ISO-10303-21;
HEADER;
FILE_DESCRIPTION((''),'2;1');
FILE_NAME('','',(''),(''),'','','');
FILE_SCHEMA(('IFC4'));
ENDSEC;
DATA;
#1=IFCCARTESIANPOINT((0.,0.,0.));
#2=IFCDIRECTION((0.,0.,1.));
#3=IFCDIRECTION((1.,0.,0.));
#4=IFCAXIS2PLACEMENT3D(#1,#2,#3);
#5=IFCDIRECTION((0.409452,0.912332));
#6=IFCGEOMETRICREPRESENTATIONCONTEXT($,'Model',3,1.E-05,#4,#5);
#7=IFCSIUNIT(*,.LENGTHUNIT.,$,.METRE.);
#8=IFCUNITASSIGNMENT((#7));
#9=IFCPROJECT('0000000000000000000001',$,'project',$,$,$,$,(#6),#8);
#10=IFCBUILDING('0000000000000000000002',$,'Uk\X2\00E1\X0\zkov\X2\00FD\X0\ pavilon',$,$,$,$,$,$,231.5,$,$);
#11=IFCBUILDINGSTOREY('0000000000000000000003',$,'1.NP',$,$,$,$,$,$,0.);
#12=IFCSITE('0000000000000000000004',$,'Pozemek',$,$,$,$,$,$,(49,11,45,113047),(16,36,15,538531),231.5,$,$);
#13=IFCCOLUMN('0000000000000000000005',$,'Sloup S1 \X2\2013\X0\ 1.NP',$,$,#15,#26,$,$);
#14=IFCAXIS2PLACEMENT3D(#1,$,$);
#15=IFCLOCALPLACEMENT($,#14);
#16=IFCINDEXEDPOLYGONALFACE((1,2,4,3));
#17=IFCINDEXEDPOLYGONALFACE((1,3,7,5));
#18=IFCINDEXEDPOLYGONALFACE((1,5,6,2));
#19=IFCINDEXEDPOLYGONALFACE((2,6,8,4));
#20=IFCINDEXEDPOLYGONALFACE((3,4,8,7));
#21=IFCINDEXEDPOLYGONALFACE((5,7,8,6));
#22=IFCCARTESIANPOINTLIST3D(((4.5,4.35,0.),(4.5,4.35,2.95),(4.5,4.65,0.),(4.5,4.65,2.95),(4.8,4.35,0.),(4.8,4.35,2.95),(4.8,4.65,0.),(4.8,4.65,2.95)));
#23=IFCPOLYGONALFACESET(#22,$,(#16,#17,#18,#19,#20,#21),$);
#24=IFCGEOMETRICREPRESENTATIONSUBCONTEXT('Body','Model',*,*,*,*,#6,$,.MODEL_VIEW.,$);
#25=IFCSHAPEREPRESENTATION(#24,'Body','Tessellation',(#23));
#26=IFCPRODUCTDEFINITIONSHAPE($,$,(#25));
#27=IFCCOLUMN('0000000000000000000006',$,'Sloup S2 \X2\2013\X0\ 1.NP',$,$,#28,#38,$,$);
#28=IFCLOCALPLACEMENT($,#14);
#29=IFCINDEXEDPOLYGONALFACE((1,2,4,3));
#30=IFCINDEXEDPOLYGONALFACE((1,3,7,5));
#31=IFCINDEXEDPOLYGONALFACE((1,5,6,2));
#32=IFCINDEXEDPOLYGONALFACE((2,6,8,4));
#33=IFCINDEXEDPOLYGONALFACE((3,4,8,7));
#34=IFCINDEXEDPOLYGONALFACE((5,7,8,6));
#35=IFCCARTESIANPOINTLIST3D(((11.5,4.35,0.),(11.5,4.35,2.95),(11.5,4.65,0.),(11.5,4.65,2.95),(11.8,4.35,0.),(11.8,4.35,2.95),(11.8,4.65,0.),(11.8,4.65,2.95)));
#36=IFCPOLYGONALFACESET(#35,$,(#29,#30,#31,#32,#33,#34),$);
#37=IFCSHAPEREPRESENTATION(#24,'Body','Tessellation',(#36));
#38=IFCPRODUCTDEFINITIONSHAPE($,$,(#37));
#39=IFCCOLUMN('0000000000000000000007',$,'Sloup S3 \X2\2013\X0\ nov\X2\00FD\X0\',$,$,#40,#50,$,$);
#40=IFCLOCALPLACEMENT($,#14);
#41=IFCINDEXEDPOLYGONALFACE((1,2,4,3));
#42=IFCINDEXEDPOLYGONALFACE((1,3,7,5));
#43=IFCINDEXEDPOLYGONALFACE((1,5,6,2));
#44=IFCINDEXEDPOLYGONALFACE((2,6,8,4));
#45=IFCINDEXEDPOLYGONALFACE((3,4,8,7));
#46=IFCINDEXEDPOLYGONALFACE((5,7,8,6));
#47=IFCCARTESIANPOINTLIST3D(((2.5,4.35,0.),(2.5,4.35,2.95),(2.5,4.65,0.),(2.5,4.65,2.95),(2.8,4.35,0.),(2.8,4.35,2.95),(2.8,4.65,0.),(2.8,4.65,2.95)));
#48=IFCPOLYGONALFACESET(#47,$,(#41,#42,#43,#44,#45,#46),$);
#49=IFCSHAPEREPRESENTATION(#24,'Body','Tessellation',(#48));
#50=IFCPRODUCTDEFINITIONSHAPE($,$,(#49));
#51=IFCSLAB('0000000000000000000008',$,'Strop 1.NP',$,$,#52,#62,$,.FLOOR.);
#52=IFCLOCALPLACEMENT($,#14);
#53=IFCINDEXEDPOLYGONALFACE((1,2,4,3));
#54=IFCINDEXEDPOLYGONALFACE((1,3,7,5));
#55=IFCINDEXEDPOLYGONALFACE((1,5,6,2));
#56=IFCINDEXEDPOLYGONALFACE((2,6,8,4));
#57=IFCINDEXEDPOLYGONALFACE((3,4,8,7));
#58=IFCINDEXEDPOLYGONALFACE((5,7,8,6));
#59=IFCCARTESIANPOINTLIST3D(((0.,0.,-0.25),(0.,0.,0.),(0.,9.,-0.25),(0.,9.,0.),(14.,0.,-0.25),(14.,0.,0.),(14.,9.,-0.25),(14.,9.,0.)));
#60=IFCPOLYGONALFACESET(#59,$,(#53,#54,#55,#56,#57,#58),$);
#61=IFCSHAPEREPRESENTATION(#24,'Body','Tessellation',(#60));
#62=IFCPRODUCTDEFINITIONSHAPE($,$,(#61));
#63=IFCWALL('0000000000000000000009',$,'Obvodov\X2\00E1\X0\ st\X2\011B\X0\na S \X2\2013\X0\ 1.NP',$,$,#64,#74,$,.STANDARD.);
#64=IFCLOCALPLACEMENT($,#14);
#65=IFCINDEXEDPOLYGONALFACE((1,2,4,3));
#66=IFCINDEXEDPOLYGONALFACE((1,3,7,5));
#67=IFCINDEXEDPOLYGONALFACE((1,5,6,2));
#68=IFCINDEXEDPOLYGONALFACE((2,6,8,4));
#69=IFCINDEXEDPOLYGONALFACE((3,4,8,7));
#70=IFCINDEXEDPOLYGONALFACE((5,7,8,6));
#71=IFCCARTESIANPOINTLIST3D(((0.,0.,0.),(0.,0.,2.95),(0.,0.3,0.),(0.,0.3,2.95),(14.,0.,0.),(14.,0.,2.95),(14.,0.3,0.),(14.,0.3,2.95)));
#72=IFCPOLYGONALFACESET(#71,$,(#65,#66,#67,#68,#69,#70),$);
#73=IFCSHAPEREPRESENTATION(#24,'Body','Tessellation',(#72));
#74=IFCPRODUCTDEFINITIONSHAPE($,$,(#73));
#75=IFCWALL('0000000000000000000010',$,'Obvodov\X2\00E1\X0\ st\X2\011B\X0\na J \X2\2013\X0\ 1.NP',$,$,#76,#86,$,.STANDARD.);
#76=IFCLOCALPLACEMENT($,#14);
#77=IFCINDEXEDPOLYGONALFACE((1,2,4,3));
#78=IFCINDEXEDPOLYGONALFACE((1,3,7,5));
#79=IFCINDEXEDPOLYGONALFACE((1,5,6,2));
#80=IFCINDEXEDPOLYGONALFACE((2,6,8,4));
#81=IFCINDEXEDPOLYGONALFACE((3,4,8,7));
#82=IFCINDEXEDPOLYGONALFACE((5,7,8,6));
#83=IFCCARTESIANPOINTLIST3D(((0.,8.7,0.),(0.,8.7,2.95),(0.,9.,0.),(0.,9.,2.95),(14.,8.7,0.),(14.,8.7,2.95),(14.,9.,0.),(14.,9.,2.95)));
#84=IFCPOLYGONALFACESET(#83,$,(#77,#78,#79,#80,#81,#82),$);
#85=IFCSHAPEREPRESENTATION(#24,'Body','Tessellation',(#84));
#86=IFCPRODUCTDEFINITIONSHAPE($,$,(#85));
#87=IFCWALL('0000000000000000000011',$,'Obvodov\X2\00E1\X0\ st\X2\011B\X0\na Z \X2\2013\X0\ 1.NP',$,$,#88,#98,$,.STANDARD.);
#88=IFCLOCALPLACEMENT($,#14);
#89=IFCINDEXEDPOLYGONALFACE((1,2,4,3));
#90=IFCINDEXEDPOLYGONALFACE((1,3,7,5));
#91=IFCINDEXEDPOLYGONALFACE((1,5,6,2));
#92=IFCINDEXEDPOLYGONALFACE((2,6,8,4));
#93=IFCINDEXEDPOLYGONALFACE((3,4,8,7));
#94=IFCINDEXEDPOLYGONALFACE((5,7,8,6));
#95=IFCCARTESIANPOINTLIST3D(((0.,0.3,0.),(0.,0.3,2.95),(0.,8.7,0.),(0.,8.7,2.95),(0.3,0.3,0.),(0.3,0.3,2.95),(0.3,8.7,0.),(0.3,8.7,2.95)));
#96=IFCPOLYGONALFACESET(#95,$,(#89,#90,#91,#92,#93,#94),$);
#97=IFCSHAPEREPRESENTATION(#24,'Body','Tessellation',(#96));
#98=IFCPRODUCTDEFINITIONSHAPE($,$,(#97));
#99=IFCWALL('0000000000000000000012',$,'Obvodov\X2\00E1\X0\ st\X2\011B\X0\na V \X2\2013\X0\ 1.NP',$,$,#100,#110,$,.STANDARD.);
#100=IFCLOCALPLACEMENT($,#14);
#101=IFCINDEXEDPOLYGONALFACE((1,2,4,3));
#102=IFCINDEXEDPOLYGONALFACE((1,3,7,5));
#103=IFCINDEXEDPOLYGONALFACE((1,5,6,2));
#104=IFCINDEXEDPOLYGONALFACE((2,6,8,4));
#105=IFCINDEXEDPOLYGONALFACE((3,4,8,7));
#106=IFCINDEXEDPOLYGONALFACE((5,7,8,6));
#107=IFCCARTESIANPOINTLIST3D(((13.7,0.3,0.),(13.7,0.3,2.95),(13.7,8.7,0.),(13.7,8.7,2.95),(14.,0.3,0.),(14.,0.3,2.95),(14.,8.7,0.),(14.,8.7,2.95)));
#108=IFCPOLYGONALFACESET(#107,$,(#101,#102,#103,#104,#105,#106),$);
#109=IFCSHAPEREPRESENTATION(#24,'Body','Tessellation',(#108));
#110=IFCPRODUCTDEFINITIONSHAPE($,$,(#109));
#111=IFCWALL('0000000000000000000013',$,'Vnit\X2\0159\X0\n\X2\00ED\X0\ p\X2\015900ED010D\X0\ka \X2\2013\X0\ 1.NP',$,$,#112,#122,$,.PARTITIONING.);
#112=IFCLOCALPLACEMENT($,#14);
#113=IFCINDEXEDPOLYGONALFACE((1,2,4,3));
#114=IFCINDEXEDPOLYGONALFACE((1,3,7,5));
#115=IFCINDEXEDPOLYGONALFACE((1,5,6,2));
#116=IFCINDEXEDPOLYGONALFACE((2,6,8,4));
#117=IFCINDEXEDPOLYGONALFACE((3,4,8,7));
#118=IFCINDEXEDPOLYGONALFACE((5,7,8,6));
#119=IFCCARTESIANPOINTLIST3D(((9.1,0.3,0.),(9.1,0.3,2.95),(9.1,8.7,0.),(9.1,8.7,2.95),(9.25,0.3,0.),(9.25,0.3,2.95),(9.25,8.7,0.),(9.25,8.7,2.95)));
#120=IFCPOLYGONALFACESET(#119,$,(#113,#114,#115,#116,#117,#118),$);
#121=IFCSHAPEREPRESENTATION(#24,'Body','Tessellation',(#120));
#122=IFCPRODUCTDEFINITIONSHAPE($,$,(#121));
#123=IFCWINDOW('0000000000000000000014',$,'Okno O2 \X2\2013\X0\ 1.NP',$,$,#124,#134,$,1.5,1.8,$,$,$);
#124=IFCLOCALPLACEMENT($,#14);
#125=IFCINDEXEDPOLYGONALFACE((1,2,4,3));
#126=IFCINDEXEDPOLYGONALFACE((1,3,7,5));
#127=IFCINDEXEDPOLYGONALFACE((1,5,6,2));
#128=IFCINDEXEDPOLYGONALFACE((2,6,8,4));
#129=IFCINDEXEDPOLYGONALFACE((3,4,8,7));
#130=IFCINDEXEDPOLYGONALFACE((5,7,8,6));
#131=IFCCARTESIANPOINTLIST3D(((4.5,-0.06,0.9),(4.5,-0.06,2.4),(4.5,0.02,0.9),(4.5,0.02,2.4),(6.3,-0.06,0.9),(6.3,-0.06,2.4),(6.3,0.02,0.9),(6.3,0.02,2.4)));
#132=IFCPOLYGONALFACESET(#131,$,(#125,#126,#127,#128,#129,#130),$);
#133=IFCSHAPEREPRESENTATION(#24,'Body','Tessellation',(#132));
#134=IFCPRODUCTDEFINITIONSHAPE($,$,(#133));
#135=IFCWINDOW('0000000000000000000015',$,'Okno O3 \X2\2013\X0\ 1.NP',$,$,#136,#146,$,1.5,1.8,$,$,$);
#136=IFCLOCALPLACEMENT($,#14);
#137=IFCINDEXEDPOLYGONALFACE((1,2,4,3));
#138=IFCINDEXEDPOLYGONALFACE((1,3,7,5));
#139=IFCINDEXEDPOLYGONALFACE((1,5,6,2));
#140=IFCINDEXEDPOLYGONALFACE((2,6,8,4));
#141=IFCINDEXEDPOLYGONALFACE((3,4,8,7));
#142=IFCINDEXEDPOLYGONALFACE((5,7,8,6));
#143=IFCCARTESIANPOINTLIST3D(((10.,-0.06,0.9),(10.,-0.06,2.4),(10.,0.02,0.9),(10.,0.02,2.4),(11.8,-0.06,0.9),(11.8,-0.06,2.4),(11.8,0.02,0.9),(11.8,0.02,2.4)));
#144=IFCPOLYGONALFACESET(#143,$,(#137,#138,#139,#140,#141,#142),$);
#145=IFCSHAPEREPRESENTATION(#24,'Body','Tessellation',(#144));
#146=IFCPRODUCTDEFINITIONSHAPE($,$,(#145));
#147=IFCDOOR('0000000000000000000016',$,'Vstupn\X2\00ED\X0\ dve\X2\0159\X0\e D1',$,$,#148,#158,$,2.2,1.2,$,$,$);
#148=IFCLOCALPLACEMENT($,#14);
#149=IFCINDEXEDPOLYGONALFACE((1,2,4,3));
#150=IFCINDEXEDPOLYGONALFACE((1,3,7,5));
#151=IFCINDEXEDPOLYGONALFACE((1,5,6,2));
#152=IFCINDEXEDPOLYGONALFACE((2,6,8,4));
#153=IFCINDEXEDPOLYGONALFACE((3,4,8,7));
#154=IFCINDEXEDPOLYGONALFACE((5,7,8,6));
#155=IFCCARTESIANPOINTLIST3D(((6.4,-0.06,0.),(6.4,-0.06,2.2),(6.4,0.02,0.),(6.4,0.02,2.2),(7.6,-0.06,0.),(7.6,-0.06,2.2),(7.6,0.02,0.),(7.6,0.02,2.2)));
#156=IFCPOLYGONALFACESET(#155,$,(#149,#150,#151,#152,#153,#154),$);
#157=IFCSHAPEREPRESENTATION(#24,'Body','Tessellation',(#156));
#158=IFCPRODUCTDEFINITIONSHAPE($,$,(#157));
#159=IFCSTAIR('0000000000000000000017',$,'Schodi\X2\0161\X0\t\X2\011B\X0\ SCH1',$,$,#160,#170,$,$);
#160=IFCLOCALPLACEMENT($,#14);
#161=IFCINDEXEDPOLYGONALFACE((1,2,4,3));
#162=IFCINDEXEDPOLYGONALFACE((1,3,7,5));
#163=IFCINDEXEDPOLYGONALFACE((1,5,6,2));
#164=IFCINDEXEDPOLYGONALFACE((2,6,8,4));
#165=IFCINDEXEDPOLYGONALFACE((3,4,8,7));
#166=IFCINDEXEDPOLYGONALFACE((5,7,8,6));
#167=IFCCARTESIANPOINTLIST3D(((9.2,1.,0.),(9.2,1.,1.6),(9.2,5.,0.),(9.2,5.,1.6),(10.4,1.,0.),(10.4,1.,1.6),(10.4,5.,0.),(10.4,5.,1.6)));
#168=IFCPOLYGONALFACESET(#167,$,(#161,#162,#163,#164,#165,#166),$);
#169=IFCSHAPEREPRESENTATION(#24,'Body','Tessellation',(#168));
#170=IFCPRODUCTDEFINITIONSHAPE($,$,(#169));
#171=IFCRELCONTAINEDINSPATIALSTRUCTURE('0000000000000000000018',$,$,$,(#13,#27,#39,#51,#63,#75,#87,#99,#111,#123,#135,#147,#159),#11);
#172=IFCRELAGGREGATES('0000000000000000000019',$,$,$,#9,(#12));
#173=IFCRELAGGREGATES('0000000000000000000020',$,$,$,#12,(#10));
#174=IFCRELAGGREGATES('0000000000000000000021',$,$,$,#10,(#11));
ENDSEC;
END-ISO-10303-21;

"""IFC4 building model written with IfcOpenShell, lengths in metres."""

from ifc_helpers import new_model, si_unit, direction, frame, frame_2d, origin, origin_with_axes, place, context, subcontext, project, spatial, rectangle, extrude, element, save


model = new_model("IFC4")

# Units and contexts
model_context = context("Model", 3, precision=1e-05, world=origin_with_axes(), true_north=direction((0.409452, 0.912332)))
body_context = subcontext(model_context, "Body", "Model", "MODEL_VIEW")
ifc_project = project(units=[si_unit("LENGTHUNIT", "METRE")], contexts=[model_context])

# Site, building, storey
site = spatial("IfcSite", under=ifc_project, Name="Pozemek", RefLatitude=(49, 11, 45, 113047), RefLongitude=(16, 36, 15, 538531), RefElevation=231.5)
building = spatial("IfcBuilding", under=site, Name="Ukázkový pavilon", ElevationOfRefHeight=231.5)
storey = spatial("IfcBuildingStorey", under=building, Name="1.NP", Elevation=0.0)

# Columns
for number, where, z_axis, x_axis, name in (
    (1, (4.5, 4.35, 0.0), (0.0, 0.0, 1.0), (1.0, 0.0, 0.0), "Sloup S1 – 1.NP"),
    (2, (11.5, 4.35, 0.0), (0.0, 0.0, 1.0), (1.0, 0.0, 0.0), "Sloup S2 – 1.NP"),
    (3, (2.5, 4.35, 0.0), (0.0, 0.0, 1.0), (1.0, 0.0, 0.0), "Sloup S3 – nový"),
):
    element("IfcColumn", number, at=place(None, frame(where, z_axis=z_axis, x_axis=x_axis)), inside=storey, Name=name, context=body_context, shape_type="SweptSolid", body=[
        extrude(rectangle(XDim=0.3, YDim=0.3, at=frame_2d((0.15, 0.15))), origin(), (0.0, 0.0, 1.0), 2.95),
    ])

# Slab
slab_placement = place(None, frame((0.0, 0.0, -0.25), z_axis=(0.0, 0.0, 1.0), x_axis=(1.0, 0.0, 0.0)))
element("IfcSlab", 4, at=slab_placement, inside=storey, Name="Strop 1.NP", PredefinedType="FLOOR", context=body_context, shape_type="SweptSolid", body=[
    extrude(rectangle(XDim=14.0, YDim=9.0, at=frame_2d((7.0, 4.5))), origin(), (0.0, 0.0, 1.0), 0.25),
])

# Walls
for number, where, z_axis, x_axis, name in (
    (5, (0.0, 0.0, 0.0), (0.0, 0.0, 1.0), (1.0, 0.0, 0.0), "Obvodová stěna S – 1.NP"),
    (6, (0.0, 8.7, 0.0), (0.0, 0.0, 1.0), (1.0, 0.0, 0.0), "Obvodová stěna J – 1.NP"),
):
    element("IfcWall", number, at=place(None, frame(where, z_axis=z_axis, x_axis=x_axis)), inside=storey, Name=name, PredefinedType="STANDARD", context=body_context, shape_type="SweptSolid", body=[
        extrude(rectangle(XDim=14.0, YDim=0.3, at=frame_2d((7.0, 0.15))), origin(), (0.0, 0.0, 1.0), 2.95),
    ])
for number, where, z_axis, x_axis, name in (
    (7, (0.0, 0.3, 0.0), (0.0, 0.0, 1.0), (1.0, 0.0, 0.0), "Obvodová stěna Z – 1.NP"),
    (8, (13.7, 0.3, 0.0), (0.0, 0.0, 1.0), (1.0, 0.0, 0.0), "Obvodová stěna V – 1.NP"),
):
    element("IfcWall", number, at=place(None, frame(where, z_axis=z_axis, x_axis=x_axis)), inside=storey, Name=name, PredefinedType="STANDARD", context=body_context, shape_type="SweptSolid", body=[
        extrude(rectangle(XDim=0.3, YDim=8.4, at=frame_2d((0.15, 4.2))), origin(), (0.0, 0.0, 1.0), 2.95),
    ])
wall_placement = place(None, frame((9.1, 0.3, 0.0), z_axis=(0.0, 0.0, 1.0), x_axis=(1.0, 0.0, 0.0)))
element("IfcWall", 9, at=wall_placement, inside=storey, Name="Vnitřní příčka – 1.NP", PredefinedType="PARTITIONING", context=body_context, shape_type="SweptSolid", body=[
    extrude(rectangle(XDim=0.15, YDim=8.4, at=frame_2d((0.075, 4.2))), origin(), (0.0, 0.0, 1.0), 2.95),
])

# Windows
for number, where, z_axis, x_axis, name in (
    (10, (4.5, -0.06, 0.9), (0.0, 0.0, 1.0), (1.0, 0.0, 0.0), "Okno O2 – 1.NP"),
    (11, (10.0, -0.06, 0.9), (0.0, 0.0, 1.0), (1.0, 0.0, 0.0), "Okno O3 – 1.NP"),
):
    element("IfcWindow", number, at=place(None, frame(where, z_axis=z_axis, x_axis=x_axis)), inside=storey, Name=name, OverallHeight=1.5, OverallWidth=1.8, context=body_context, shape_type="SweptSolid", body=[
        extrude(rectangle(XDim=1.8, YDim=0.08, at=frame_2d((0.9, 0.04))), origin(), (0.0, 0.0, 1.0), 1.5),
    ])

# Door
door_placement = place(None, frame((6.4, -0.06, 0.0), z_axis=(0.0, 0.0, 1.0), x_axis=(1.0, 0.0, 0.0)))
element("IfcDoor", 12, at=door_placement, inside=storey, Name="Vstupní dveře D1", OverallHeight=2.2, OverallWidth=1.2, context=body_context, shape_type="SweptSolid", body=[
    extrude(rectangle(XDim=1.2, YDim=0.08, at=frame_2d((0.6, 0.04))), origin(), (0.0, 0.0, 1.0), 2.2),
])

# Stair
stair_placement = place(None, frame((9.2, 1.0, 0.0), z_axis=(0.0, 0.0, 1.0), x_axis=(1.0, 0.0, 0.0)))
element("IfcStair", 13, at=stair_placement, inside=storey, Name="Schodiště SCH1", context=body_context, shape_type="SweptSolid", body=[
    extrude(rectangle(XDim=1.2, YDim=4.0, at=frame_2d((0.6, 2.0))), origin(), (0.0, 0.0, 1.0), 1.6),
])

save(model, "model.ifc")
